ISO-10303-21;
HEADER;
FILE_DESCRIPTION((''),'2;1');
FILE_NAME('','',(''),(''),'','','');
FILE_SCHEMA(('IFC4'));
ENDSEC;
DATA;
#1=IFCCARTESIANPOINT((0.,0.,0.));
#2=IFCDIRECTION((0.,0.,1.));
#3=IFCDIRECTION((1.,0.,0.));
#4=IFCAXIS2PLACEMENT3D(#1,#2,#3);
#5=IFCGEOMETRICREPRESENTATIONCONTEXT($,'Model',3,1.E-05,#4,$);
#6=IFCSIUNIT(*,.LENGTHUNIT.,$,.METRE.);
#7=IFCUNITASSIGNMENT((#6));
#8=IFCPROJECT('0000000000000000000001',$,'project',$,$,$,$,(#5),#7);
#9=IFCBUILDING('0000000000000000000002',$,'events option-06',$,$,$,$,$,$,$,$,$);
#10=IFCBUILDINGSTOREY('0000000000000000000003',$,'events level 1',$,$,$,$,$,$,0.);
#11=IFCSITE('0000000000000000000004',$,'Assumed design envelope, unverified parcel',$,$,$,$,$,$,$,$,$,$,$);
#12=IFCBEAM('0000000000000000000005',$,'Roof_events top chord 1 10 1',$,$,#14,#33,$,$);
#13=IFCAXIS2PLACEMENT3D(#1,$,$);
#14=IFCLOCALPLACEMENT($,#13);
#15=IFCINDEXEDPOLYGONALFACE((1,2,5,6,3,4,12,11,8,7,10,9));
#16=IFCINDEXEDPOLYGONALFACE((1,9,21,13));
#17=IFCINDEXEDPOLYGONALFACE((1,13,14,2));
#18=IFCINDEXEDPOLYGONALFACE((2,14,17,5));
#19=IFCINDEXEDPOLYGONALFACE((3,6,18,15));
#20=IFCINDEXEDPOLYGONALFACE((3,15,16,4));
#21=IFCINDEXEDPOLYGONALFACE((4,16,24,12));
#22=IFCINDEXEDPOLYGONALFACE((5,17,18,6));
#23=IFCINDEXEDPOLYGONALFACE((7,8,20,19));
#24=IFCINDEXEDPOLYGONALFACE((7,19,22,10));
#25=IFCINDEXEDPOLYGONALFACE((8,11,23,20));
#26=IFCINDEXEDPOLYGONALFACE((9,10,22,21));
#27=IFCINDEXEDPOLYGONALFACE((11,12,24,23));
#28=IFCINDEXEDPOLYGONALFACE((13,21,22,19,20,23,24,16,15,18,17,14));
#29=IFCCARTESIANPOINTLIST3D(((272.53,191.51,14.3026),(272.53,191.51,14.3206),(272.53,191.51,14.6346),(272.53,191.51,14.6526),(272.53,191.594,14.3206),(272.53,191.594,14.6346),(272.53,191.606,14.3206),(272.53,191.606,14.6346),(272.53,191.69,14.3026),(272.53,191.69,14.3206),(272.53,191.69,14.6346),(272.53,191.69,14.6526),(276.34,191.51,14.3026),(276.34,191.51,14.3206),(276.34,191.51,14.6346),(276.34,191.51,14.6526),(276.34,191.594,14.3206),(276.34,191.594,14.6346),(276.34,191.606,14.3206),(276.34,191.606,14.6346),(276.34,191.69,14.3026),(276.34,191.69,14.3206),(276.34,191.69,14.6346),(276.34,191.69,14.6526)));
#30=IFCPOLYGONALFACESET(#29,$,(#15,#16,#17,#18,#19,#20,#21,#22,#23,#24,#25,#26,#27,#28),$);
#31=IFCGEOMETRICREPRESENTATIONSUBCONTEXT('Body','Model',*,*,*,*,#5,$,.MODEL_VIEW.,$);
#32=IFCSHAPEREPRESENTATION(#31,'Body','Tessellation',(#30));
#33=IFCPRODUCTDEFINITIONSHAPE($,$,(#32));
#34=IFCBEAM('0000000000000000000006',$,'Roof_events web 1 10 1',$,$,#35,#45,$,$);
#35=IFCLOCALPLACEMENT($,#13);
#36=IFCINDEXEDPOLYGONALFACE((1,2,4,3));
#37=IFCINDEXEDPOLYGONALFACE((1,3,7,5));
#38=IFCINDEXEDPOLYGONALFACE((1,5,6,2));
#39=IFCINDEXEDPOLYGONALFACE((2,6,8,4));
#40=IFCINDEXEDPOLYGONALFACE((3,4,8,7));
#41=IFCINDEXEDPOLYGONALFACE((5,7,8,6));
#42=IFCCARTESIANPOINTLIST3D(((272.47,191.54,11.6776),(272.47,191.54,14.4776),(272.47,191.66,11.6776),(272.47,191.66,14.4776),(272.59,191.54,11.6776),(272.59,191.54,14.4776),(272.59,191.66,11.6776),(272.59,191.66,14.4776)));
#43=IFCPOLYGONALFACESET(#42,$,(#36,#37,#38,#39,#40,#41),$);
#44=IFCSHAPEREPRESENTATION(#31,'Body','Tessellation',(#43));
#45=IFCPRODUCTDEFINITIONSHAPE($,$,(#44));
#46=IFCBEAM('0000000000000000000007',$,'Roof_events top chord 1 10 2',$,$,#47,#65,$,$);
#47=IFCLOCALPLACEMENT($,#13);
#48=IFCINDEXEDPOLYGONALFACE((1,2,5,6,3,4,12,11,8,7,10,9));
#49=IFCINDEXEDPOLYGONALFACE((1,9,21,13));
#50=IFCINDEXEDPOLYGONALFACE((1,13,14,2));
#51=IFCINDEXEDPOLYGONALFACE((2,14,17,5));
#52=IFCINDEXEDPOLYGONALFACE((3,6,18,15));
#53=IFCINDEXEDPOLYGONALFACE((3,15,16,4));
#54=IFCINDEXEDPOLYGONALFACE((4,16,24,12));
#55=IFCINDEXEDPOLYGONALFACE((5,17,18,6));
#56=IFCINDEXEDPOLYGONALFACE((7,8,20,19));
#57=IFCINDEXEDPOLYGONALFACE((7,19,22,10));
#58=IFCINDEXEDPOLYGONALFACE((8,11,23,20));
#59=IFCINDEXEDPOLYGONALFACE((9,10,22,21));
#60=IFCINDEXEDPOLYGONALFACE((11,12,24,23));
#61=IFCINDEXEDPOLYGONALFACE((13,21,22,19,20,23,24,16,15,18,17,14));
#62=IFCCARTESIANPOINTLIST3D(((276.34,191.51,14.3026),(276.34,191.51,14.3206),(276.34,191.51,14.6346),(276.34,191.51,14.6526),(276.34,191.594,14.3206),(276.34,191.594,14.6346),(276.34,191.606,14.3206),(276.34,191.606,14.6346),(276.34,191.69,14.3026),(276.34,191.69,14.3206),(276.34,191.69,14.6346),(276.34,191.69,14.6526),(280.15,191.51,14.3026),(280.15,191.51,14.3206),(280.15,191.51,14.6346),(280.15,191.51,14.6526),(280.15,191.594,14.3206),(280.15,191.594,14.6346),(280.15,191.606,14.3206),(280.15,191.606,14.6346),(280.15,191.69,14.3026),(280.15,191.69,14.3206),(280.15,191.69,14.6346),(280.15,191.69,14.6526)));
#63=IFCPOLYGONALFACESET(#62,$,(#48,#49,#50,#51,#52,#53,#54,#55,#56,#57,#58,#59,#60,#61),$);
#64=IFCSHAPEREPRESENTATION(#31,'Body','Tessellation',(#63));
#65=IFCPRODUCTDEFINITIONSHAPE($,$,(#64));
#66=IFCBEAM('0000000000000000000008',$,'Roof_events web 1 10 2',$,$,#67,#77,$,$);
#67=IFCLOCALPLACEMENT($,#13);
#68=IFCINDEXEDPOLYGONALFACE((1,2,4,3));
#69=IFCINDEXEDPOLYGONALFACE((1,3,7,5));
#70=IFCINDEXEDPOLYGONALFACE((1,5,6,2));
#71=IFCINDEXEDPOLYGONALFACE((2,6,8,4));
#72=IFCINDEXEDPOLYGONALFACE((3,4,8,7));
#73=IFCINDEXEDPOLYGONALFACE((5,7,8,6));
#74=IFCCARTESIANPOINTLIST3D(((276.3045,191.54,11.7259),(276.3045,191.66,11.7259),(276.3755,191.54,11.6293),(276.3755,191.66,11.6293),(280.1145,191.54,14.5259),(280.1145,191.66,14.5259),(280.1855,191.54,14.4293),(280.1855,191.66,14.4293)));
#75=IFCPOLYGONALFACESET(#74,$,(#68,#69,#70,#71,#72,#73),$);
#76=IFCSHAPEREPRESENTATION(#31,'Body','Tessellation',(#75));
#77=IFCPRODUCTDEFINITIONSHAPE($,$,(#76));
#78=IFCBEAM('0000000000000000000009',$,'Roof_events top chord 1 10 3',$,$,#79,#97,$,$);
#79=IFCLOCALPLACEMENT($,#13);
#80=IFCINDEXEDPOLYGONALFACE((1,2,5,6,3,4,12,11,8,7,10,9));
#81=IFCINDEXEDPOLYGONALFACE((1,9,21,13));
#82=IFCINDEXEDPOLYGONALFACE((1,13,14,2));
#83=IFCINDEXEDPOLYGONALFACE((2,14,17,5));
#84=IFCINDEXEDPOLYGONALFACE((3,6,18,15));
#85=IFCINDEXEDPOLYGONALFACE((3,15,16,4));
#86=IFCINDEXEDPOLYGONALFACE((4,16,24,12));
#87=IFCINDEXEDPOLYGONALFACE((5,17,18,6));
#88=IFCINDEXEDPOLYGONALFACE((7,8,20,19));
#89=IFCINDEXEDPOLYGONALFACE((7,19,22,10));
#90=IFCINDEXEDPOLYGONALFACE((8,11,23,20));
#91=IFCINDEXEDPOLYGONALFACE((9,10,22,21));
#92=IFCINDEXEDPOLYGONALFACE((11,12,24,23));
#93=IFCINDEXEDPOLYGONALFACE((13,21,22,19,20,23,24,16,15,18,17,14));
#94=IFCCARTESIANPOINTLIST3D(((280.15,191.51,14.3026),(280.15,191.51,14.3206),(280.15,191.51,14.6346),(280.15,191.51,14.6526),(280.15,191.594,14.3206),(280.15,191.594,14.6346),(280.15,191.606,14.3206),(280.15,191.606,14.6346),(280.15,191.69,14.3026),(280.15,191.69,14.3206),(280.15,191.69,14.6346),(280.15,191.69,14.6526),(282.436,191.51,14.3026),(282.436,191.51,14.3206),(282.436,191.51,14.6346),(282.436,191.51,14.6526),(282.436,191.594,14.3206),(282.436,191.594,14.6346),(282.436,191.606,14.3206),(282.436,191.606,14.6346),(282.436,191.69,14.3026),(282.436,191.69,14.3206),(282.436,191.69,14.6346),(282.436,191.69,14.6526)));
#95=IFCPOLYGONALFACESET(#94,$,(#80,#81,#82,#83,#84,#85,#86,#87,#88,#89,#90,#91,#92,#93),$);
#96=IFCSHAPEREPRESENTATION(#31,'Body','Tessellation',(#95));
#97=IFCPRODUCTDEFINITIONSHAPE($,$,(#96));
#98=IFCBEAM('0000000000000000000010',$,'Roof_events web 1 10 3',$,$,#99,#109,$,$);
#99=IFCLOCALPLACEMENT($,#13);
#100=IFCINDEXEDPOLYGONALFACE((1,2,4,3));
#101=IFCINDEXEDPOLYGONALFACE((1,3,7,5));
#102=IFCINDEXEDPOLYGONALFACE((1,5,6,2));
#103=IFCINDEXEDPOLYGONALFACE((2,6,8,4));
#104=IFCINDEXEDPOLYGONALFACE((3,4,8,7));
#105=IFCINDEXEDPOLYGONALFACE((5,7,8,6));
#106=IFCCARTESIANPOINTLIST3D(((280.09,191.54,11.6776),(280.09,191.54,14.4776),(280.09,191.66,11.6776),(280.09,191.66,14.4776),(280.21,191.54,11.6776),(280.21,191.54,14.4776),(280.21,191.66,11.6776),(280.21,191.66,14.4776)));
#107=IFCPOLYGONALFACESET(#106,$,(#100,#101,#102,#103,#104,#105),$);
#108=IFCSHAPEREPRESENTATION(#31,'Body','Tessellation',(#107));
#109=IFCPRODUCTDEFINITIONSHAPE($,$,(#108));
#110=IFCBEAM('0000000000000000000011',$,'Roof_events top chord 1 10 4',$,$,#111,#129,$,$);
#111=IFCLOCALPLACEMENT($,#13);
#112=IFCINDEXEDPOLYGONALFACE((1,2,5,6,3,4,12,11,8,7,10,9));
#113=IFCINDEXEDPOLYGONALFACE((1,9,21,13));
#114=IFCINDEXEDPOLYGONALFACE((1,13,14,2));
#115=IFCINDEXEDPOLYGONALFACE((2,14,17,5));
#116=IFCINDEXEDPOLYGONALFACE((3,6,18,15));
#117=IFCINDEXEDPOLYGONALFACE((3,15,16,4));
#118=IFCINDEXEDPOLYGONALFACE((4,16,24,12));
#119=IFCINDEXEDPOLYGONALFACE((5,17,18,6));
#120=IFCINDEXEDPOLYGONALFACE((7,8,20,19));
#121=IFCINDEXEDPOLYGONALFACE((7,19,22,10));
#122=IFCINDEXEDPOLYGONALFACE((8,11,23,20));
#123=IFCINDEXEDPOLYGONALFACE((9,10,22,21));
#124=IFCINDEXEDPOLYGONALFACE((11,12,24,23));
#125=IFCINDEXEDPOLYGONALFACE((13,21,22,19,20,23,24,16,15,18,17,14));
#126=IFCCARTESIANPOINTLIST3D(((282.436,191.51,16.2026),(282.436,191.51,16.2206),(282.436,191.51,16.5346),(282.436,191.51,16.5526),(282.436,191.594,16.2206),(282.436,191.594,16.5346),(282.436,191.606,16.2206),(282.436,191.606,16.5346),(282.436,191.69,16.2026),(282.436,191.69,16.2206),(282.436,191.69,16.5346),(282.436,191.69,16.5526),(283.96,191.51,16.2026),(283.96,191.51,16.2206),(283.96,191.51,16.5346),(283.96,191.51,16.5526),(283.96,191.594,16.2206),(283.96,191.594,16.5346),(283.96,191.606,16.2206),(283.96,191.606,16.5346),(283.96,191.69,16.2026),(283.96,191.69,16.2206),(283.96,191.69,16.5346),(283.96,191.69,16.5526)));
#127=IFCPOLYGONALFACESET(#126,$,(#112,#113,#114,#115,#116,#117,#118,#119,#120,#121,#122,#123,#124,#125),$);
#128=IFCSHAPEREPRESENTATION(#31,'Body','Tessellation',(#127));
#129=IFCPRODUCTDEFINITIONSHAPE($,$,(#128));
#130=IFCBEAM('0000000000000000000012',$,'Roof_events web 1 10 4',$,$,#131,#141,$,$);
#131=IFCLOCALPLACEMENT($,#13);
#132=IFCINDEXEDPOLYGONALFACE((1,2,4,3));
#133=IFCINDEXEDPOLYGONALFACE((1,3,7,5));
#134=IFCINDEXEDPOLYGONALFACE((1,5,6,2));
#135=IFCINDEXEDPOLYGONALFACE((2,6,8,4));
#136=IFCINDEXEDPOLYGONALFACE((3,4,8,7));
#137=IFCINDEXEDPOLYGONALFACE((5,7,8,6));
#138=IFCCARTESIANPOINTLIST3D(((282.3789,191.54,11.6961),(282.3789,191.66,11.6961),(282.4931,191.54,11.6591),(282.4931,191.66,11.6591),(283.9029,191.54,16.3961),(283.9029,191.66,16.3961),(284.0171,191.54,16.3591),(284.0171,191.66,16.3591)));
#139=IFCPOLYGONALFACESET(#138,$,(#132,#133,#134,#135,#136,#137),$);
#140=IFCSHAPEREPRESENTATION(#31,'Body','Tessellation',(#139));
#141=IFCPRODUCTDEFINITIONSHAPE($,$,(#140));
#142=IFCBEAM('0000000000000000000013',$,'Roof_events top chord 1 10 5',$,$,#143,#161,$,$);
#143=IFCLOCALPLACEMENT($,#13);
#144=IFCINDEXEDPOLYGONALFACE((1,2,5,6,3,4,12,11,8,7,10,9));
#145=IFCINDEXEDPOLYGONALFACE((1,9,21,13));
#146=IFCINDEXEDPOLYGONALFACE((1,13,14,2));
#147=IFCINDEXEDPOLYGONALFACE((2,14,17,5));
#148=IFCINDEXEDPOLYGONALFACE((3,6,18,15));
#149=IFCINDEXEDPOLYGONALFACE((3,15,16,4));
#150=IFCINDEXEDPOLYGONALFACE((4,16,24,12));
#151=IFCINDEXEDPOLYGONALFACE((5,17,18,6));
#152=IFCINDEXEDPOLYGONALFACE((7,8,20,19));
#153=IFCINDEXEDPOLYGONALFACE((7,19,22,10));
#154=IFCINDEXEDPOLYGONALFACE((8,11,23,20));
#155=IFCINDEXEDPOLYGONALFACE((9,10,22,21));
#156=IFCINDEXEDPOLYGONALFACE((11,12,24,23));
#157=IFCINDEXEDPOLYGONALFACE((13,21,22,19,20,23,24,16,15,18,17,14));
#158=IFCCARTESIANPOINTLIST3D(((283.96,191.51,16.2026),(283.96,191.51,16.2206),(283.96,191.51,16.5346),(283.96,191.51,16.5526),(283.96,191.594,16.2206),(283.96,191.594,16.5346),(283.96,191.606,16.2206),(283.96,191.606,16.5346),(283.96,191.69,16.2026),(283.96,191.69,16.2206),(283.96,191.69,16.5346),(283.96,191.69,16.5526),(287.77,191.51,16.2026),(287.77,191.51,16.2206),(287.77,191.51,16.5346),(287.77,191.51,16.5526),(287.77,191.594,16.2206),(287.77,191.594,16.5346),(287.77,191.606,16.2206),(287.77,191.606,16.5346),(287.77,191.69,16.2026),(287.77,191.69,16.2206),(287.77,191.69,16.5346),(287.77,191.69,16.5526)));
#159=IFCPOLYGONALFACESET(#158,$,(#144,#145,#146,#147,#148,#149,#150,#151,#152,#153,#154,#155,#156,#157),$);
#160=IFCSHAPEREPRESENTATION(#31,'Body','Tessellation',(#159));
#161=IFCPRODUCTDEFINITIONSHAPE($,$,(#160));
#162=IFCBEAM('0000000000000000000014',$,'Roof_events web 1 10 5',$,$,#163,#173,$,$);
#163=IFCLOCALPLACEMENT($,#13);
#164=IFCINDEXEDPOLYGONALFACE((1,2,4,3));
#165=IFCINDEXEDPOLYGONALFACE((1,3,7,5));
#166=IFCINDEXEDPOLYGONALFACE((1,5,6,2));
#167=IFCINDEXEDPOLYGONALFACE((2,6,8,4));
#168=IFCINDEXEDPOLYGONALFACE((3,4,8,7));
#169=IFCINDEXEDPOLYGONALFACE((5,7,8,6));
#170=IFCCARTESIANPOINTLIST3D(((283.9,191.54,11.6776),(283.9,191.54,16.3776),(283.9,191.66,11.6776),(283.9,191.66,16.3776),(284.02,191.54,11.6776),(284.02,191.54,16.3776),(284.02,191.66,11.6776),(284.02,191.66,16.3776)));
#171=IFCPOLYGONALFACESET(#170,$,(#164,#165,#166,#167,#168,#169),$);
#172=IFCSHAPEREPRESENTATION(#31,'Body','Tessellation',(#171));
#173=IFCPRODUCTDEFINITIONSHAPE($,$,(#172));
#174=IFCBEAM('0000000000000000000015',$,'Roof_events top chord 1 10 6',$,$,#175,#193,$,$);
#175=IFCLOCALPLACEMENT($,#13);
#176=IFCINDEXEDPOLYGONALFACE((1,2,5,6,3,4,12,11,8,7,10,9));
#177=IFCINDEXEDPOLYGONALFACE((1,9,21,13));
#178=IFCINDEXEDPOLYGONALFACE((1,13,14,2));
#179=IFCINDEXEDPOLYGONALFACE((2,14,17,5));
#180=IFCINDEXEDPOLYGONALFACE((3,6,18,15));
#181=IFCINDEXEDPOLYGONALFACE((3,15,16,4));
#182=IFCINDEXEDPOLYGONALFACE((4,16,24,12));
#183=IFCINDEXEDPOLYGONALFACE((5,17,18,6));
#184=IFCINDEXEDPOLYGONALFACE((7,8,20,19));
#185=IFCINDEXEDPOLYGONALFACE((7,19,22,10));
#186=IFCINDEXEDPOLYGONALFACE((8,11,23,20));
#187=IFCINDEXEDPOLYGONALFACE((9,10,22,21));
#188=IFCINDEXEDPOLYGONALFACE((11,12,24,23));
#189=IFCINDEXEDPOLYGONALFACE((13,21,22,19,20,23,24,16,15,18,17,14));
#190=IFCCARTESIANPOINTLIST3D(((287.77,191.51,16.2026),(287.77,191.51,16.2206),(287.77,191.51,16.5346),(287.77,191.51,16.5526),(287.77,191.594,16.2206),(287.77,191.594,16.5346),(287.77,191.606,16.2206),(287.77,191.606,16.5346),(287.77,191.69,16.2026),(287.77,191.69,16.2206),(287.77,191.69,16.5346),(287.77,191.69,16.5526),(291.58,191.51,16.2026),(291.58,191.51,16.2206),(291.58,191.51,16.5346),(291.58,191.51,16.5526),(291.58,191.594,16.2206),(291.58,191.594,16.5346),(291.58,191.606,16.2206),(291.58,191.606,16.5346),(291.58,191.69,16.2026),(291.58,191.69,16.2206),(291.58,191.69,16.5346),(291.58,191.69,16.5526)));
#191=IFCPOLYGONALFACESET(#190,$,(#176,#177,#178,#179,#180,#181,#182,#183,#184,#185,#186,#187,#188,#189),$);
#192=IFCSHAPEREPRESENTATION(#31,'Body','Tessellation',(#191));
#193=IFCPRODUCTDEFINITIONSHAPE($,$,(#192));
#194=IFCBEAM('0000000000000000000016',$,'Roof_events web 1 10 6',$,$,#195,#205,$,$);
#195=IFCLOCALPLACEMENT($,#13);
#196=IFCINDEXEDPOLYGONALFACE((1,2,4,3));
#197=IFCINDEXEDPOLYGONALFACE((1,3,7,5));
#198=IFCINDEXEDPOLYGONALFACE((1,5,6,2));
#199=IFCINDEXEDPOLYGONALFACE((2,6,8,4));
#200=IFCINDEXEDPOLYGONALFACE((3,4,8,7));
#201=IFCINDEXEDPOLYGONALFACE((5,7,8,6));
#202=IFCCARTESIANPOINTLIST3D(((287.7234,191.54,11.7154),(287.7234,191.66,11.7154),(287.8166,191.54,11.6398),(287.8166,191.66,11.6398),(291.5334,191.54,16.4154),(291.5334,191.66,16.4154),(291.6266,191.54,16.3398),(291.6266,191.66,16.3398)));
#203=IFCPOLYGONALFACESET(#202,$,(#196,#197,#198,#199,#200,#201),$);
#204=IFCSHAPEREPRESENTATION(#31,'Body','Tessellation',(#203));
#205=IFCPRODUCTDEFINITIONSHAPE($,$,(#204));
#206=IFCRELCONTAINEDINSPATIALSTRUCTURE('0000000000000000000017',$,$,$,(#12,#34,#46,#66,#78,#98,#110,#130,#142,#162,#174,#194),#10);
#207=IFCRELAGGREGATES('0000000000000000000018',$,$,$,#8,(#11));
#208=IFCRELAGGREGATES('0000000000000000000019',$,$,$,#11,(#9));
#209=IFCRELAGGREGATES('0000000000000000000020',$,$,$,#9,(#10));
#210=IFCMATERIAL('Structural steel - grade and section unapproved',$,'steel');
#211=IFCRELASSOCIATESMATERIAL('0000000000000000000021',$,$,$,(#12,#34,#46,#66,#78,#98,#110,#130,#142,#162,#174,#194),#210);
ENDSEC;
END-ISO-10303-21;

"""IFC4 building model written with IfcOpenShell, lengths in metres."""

from ifc_helpers import new_model, si_unit, frame, origin_with_axes, place, context, subcontext, project, spatial, rectangle, i_section, extrude, material, element, save


model = new_model("IFC4")

# Units and contexts
model_context = context("Model", 3, precision=1e-05, world=origin_with_axes())
body_context = subcontext(model_context, "Body", "Model", "MODEL_VIEW")
ifc_project = project(units=[si_unit("LENGTHUNIT", "METRE")], contexts=[model_context])

# Site, building, storey
site = spatial("IfcSite", under=ifc_project, Name="Assumed design envelope, unverified parcel")
building = spatial("IfcBuilding", under=site, Name="events option-06")
storey = spatial("IfcBuildingStorey", under=building, Name="events level 1", Elevation=0.0)

# Beams
ifc_material_1 = material(Name="Structural steel - grade and section unapproved", Category="steel")
beam_1_placement = place(None, frame((272.53, 191.6, 14.4776), z_axis=(1.0, 0.0, 0.0), x_axis=(0.0, 1.0, 0.0)))
element("IfcBeam", 1, at=beam_1_placement, inside=storey, material=ifc_material_1, Name="Roof_events top chord 1 10 1", context=body_context, shape_type="SweptSolid", body=[
    extrude(i_section(OverallWidth=0.18, OverallDepth=0.35, WebThickness=0.012, FlangeThickness=0.018, FilletRadius=0.0), origin_with_axes(), (0.0, 0.0, 1.0), 3.81),
])
beam_2_placement = place(None, frame((272.53, 191.6, 11.6776), z_axis=(0.0, 0.0, 1.0), x_axis=(-1.0, 0.0, 0.0)))
element("IfcBeam", 2, at=beam_2_placement, inside=storey, material=ifc_material_1, Name="Roof_events web 1 10 1", context=body_context, shape_type="SweptSolid", body=[
    extrude(rectangle(XDim=0.12, YDim=0.12), origin_with_axes(), (0.0, 0.0, 1.0), 2.8),
])
beam_3_placement = place(None, frame((276.34, 191.6, 14.4776), z_axis=(1.0, 0.0, 0.0), x_axis=(0.0, 1.0, 0.0)))
element("IfcBeam", 3, at=beam_3_placement, inside=storey, material=ifc_material_1, Name="Roof_events top chord 1 10 2", context=body_context, shape_type="SweptSolid", body=[
    extrude(i_section(OverallWidth=0.18, OverallDepth=0.35, WebThickness=0.012, FlangeThickness=0.018, FilletRadius=0.0), origin_with_axes(), (0.0, 0.0, 1.0), 3.81),
])
beam_4_placement = place(None, frame((276.34, 191.6, 11.6776), z_axis=(0.805799, 0.0, 0.592189), x_axis=(0.0, 1.0, 0.0)))
element("IfcBeam", 4, at=beam_4_placement, inside=storey, material=ifc_material_1, Name="Roof_events web 1 10 2", context=body_context, shape_type="SweptSolid", body=[
    extrude(rectangle(XDim=0.12, YDim=0.12), origin_with_axes(), (0.0, 0.0, 1.0), 4.7282),
])
beam_5_placement = place(None, frame((280.15, 191.6, 14.4776), z_axis=(1.0, 0.0, 0.0), x_axis=(0.0, 1.0, 0.0)))
element("IfcBeam", 5, at=beam_5_placement, inside=storey, material=ifc_material_1, Name="Roof_events top chord 1 10 3", context=body_context, shape_type="SweptSolid", body=[
    extrude(i_section(OverallWidth=0.18, OverallDepth=0.35, WebThickness=0.012, FlangeThickness=0.018, FilletRadius=0.0), origin_with_axes(), (0.0, 0.0, 1.0), 2.286),
])
beam_6_placement = place(None, frame((280.15, 191.6, 11.6776), z_axis=(0.0, 0.0, 1.0), x_axis=(-1.0, 0.0, 0.0)))
element("IfcBeam", 6, at=beam_6_placement, inside=storey, material=ifc_material_1, Name="Roof_events web 1 10 3", context=body_context, shape_type="SweptSolid", body=[
    extrude(rectangle(XDim=0.12, YDim=0.12), origin_with_axes(), (0.0, 0.0, 1.0), 2.8),
])
beam_7_placement = place(None, frame((282.436, 191.6, 16.3776), z_axis=(1.0, 0.0, 0.0), x_axis=(0.0, 1.0, 0.0)))
element("IfcBeam", 7, at=beam_7_placement, inside=storey, material=ifc_material_1, Name="Roof_events top chord 1 10 4", context=body_context, shape_type="SweptSolid", body=[
    extrude(i_section(OverallWidth=0.18, OverallDepth=0.35, WebThickness=0.012, FlangeThickness=0.018, FilletRadius=0.0), origin_with_axes(), (0.0, 0.0, 1.0), 1.524),
])
beam_8_placement = place(None, frame((282.436, 191.6, 11.6776), z_axis=(0.308443, 0.0, 0.951243), x_axis=(0.0, 1.0, 0.0)))
element("IfcBeam", 8, at=beam_8_placement, inside=storey, material=ifc_material_1, Name="Roof_events web 1 10 4", context=body_context, shape_type="SweptSolid", body=[
    extrude(rectangle(XDim=0.12, YDim=0.12), origin_with_axes(), (0.0, 0.0, 1.0), 4.9409),
])
beam_9_placement = place(None, frame((283.96, 191.6, 16.3776), z_axis=(1.0, 0.0, 0.0), x_axis=(0.0, 1.0, 0.0)))
element("IfcBeam", 9, at=beam_9_placement, inside=storey, material=ifc_material_1, Name="Roof_events top chord 1 10 5", context=body_context, shape_type="SweptSolid", body=[
    extrude(i_section(OverallWidth=0.18, OverallDepth=0.35, WebThickness=0.012, FlangeThickness=0.018, FilletRadius=0.0), origin_with_axes(), (0.0, 0.0, 1.0), 3.81),
])
beam_10_placement = place(None, frame((283.96, 191.6, 11.6776), z_axis=(0.0, 0.0, 1.0), x_axis=(-1.0, 0.0, 0.0)))
element("IfcBeam", 10, at=beam_10_placement, inside=storey, material=ifc_material_1, Name="Roof_events web 1 10 5", context=body_context, shape_type="SweptSolid", body=[
    extrude(rectangle(XDim=0.12, YDim=0.12), origin_with_axes(), (0.0, 0.0, 1.0), 4.7),
])
beam_11_placement = place(None, frame((287.77, 191.6, 16.3776), z_axis=(1.0, 0.0, 0.0), x_axis=(0.0, 1.0, 0.0)))
element("IfcBeam", 11, at=beam_11_placement, inside=storey, material=ifc_material_1, Name="Roof_events top chord 1 10 6", context=body_context, shape_type="SweptSolid", body=[
    extrude(i_section(OverallWidth=0.18, OverallDepth=0.35, WebThickness=0.012, FlangeThickness=0.018, FilletRadius=0.0), origin_with_axes(), (0.0, 0.0, 1.0), 3.81),
])
beam_12_placement = place(None, frame((287.77, 191.6, 11.6776), z_axis=(0.629721, 0.0, 0.776821), x_axis=(0.0, 1.0, 0.0)))
element("IfcBeam", 12, at=beam_12_placement, inside=storey, material=ifc_material_1, Name="Roof_events web 1 10 6", context=body_context, shape_type="SweptSolid", body=[
    extrude(rectangle(XDim=0.12, YDim=0.12), origin_with_axes(), (0.0, 0.0, 1.0), 6.0503),
])

save(model, "model.ifc")
